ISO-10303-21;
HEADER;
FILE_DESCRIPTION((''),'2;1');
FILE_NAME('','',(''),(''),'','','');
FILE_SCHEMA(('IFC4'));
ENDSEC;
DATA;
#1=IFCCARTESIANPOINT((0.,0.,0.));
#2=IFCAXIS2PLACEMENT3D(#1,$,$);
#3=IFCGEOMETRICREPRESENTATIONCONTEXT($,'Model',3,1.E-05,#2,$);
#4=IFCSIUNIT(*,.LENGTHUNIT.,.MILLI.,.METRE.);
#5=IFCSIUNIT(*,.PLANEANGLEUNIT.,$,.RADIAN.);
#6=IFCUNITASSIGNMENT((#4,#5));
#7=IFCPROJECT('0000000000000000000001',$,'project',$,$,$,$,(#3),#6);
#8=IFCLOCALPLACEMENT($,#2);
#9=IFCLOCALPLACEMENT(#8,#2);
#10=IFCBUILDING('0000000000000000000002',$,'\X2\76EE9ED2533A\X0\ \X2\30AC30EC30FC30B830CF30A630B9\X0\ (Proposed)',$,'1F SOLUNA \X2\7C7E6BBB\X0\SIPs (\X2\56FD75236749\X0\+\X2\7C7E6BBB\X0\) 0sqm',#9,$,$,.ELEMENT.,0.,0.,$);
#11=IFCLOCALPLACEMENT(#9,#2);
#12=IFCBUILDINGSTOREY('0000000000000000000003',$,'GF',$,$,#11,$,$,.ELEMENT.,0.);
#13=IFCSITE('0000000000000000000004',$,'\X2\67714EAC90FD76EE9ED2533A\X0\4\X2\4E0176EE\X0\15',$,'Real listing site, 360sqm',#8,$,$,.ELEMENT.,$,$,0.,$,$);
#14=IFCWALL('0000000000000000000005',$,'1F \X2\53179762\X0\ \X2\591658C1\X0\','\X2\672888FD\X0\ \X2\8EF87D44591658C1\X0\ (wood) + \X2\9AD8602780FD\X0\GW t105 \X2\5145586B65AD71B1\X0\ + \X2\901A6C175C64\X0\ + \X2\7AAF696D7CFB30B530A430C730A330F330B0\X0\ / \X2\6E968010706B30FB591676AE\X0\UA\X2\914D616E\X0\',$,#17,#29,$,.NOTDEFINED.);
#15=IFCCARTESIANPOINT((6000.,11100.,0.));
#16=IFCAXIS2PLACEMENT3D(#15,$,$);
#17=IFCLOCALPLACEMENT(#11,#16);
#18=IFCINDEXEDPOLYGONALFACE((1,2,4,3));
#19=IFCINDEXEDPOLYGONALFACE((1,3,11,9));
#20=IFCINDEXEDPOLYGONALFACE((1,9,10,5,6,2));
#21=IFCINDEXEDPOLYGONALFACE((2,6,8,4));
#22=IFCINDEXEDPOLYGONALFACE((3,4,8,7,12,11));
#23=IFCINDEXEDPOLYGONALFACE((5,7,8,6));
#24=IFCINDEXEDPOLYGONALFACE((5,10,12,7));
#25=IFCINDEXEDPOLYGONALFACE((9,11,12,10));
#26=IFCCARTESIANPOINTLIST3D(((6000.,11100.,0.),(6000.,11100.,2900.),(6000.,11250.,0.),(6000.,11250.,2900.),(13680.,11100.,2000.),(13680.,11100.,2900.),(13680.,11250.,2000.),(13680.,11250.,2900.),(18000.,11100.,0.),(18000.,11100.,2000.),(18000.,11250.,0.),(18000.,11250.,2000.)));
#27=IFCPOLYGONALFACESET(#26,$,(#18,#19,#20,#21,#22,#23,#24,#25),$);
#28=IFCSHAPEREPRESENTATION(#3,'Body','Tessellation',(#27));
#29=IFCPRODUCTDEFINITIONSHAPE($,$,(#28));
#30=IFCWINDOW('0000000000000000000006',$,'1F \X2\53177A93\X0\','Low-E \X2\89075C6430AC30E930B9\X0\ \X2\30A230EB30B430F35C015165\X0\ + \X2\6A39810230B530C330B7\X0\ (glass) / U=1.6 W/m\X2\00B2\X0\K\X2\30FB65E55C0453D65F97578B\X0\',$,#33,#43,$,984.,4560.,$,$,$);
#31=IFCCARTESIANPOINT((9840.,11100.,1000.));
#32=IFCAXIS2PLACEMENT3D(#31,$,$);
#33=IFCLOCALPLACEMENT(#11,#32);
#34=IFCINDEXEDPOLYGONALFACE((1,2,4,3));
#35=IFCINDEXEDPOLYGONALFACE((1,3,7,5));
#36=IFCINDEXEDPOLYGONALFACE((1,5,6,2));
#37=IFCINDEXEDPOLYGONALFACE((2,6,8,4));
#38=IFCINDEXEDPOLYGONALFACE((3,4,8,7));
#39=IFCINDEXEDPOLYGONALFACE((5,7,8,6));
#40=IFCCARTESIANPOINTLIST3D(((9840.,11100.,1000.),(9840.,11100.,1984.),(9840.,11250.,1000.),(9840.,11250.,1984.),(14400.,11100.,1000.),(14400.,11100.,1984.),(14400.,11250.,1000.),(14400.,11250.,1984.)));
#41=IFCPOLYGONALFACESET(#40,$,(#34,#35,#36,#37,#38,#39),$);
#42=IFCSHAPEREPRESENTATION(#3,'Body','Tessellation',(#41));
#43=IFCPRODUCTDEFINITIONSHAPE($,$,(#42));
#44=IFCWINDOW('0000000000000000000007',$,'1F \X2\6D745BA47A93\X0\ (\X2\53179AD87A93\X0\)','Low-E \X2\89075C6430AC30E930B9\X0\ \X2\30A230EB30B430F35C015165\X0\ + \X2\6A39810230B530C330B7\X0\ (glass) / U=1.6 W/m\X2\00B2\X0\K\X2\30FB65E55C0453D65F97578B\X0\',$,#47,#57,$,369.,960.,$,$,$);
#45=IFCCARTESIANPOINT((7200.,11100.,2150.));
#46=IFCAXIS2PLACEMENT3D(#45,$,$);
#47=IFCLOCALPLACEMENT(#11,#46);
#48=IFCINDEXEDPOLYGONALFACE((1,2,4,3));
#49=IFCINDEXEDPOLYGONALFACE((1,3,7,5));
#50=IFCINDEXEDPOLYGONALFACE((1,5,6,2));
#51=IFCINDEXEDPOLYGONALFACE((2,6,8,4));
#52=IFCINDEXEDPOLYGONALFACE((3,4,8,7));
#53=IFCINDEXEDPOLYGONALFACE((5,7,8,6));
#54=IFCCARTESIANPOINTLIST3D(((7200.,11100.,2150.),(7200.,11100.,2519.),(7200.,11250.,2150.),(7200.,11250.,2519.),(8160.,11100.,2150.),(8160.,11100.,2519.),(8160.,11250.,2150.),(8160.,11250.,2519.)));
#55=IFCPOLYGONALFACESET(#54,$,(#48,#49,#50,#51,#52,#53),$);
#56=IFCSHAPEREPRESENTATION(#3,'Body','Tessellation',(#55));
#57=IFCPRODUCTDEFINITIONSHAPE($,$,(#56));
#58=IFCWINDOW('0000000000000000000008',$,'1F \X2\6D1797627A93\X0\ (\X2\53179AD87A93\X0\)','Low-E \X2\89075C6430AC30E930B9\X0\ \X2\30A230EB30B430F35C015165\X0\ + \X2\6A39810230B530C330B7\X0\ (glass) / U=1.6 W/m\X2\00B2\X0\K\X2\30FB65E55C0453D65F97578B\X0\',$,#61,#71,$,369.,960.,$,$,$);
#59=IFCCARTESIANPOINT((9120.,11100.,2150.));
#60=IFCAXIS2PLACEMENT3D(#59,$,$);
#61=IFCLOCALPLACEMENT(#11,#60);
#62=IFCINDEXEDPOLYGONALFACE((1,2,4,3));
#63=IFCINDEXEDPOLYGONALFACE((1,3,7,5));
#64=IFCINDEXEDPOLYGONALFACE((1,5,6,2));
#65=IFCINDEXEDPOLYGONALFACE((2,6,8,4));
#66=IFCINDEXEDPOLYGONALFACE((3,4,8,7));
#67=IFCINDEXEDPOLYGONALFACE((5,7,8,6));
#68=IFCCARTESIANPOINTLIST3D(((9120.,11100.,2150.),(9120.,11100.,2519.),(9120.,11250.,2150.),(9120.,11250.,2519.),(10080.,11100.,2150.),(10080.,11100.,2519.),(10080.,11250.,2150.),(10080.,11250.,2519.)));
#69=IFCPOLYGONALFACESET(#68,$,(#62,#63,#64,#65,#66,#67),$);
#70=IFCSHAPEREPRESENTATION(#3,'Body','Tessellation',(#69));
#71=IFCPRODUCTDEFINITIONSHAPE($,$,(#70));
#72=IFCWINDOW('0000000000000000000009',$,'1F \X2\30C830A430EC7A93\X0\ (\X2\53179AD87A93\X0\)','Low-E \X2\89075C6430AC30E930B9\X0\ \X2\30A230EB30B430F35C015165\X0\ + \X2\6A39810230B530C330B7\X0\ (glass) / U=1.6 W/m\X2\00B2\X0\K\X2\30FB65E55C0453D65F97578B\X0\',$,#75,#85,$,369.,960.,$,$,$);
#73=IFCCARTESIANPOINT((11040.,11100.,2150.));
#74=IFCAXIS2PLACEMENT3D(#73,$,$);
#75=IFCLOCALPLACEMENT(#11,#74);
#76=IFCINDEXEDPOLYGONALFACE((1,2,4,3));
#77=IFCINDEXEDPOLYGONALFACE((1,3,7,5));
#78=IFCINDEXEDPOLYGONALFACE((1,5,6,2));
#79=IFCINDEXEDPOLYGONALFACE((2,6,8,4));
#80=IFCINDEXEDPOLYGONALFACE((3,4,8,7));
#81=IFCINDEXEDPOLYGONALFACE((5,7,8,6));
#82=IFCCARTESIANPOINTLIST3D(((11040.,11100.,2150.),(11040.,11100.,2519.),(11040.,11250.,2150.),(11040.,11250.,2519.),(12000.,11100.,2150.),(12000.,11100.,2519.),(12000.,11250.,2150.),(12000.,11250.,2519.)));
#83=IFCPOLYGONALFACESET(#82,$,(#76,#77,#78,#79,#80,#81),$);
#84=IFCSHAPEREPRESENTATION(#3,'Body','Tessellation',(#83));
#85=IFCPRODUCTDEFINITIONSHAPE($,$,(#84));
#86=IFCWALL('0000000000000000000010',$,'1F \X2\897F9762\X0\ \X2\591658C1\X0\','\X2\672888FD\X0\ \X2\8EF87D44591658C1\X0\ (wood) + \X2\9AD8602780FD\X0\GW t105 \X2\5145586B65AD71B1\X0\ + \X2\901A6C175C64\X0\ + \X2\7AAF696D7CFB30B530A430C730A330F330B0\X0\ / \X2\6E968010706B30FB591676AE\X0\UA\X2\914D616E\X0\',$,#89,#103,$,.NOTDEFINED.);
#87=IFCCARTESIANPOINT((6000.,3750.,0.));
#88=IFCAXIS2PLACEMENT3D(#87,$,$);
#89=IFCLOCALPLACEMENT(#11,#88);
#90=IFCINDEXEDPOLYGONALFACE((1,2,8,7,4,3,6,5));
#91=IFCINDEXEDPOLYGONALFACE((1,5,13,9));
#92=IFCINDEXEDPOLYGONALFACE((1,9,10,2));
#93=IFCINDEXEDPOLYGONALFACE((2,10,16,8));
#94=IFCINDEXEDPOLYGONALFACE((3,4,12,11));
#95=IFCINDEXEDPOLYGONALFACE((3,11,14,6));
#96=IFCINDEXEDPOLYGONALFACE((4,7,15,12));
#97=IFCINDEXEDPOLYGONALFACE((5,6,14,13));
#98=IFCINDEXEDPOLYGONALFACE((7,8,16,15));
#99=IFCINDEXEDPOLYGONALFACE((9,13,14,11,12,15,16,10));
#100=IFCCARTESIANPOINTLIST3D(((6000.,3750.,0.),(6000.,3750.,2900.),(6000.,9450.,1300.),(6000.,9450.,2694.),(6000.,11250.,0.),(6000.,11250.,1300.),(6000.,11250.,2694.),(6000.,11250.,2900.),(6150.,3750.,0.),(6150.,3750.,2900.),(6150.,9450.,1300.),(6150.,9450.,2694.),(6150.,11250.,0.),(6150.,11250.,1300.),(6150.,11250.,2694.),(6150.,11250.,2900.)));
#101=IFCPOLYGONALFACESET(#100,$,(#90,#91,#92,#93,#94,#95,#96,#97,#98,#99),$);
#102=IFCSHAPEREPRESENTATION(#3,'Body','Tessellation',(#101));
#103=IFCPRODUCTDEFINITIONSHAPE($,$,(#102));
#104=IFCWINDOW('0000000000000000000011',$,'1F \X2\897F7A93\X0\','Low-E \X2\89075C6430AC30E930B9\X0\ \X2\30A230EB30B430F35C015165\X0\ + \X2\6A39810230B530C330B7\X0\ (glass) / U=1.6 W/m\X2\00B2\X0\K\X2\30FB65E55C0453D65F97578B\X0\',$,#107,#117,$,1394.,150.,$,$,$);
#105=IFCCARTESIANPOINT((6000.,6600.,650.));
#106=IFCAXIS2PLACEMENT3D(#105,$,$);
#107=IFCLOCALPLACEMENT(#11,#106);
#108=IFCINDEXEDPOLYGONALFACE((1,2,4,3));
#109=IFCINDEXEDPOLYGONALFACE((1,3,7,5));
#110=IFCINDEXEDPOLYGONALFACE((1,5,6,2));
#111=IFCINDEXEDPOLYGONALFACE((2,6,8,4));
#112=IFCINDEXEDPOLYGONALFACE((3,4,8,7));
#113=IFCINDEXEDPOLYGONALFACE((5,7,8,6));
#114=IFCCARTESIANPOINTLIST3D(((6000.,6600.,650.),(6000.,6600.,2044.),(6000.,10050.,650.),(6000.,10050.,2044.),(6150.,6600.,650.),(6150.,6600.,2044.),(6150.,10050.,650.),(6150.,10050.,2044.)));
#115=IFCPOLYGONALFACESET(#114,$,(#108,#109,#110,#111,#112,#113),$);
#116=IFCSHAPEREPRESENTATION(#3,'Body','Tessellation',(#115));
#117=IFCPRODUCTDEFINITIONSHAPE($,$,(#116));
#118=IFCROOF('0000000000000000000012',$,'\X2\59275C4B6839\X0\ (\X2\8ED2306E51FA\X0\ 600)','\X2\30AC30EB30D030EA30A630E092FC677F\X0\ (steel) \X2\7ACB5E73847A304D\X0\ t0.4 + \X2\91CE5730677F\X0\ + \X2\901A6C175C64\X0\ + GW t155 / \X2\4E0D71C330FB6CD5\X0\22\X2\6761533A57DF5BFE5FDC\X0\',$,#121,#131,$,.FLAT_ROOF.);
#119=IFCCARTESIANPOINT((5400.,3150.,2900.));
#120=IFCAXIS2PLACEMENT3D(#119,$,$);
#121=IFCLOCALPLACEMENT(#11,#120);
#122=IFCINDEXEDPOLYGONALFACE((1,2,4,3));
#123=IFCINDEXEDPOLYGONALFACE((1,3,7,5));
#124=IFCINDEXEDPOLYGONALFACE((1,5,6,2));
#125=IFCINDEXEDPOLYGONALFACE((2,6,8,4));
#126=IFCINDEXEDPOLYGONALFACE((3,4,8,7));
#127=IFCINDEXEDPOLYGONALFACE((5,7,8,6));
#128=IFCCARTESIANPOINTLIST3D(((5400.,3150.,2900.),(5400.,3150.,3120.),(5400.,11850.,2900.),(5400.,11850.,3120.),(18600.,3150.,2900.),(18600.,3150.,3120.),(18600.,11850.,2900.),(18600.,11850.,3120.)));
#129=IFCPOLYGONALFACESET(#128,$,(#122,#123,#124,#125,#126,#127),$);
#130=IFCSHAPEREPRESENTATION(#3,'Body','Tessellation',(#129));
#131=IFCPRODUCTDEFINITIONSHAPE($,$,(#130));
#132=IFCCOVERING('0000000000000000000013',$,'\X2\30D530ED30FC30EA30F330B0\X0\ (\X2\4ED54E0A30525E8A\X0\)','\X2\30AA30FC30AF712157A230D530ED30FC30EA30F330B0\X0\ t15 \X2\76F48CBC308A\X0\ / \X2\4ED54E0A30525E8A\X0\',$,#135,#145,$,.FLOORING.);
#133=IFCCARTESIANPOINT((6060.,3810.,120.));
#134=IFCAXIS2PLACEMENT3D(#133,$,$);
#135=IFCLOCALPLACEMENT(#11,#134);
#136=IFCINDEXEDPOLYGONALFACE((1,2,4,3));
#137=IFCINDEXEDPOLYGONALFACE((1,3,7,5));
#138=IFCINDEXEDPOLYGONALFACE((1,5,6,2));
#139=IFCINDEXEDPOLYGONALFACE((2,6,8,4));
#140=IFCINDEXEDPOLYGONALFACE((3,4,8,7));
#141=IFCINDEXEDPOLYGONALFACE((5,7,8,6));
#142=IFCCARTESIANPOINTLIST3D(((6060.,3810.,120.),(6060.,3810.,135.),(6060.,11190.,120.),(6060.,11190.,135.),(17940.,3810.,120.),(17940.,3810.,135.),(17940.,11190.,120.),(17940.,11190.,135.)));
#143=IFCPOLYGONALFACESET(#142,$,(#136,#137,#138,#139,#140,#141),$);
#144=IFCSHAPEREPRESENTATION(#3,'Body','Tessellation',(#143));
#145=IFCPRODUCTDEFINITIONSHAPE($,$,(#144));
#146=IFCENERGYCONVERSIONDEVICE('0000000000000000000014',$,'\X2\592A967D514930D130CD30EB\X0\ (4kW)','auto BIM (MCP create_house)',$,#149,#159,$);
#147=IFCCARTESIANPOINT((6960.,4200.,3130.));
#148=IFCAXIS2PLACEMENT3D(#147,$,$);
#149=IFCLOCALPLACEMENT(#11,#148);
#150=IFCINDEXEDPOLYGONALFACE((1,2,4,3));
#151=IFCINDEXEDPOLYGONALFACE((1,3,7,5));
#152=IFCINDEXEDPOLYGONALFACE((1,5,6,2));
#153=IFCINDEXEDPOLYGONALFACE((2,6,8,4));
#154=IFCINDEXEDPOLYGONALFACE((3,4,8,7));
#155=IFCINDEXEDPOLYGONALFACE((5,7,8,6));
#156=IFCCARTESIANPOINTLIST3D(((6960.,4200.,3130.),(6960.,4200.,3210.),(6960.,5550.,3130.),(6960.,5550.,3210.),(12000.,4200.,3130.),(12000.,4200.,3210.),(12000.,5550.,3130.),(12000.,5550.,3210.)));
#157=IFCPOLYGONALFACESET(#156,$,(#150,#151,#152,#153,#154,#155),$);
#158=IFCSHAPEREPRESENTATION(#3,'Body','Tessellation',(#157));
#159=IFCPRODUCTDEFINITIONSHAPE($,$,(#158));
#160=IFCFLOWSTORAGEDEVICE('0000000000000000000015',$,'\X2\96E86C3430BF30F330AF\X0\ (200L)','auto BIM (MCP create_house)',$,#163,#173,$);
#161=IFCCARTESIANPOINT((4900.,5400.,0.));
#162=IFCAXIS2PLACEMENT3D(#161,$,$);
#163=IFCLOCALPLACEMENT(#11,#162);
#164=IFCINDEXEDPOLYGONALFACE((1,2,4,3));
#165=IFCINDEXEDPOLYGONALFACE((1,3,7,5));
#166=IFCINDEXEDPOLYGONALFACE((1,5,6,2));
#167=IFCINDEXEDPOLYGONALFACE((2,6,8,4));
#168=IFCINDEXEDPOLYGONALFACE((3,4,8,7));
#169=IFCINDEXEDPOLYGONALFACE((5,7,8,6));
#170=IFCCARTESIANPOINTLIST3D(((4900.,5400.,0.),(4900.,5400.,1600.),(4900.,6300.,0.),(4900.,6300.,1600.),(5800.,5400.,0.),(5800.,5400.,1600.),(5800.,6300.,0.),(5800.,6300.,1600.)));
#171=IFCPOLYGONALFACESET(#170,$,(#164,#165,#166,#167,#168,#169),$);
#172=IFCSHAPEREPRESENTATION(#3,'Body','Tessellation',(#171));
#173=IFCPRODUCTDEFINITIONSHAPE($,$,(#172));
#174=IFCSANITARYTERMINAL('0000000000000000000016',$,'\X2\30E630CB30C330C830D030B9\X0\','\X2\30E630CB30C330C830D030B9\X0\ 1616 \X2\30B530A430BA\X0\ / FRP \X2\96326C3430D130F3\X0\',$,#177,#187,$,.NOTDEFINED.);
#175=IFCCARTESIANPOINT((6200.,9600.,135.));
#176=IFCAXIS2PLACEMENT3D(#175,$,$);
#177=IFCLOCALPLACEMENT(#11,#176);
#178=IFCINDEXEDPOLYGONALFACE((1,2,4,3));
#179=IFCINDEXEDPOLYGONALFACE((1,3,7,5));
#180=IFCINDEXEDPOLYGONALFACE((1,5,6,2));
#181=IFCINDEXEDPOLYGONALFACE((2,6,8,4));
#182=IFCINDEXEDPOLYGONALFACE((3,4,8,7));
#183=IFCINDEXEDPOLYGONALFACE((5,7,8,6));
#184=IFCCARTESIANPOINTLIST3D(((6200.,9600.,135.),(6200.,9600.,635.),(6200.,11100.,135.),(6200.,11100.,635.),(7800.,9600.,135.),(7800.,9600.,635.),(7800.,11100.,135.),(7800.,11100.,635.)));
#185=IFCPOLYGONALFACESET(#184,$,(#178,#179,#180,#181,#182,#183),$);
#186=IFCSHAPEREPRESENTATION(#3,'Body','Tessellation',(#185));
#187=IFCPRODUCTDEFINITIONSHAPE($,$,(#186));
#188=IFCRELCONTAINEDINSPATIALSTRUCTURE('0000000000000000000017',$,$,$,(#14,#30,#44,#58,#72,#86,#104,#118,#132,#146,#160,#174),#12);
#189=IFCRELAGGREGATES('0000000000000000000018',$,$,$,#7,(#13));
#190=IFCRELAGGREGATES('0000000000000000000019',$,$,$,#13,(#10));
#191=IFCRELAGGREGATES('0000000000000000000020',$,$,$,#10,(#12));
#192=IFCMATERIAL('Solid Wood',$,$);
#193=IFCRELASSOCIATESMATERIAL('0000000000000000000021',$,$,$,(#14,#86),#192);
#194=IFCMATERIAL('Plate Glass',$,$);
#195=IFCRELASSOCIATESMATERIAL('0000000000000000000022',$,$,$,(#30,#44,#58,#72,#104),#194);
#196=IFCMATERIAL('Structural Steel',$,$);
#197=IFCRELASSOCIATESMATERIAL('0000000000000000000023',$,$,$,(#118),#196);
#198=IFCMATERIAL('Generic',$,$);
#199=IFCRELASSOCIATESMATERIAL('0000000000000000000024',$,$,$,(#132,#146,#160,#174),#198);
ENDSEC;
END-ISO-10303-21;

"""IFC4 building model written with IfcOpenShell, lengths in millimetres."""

from ifc_helpers import new_model, si_unit, frame, frame_2d, origin, place, context, project, spatial, rectangle, extrude, material, element, fill, save


model = new_model("IFC4")

# Units and contexts
model_context = context("Model", 3, precision=1e-05, world=origin())
ifc_project = project(units=[si_unit("LENGTHUNIT", "METRE", prefix="MILLI"), si_unit("PLANEANGLEUNIT", "RADIAN")], contexts=[model_context])

# Site, building, storey
site_placement = place(None, origin())
site = spatial("IfcSite", under=ifc_project, at=site_placement, Name="東京都目黒区4丁目15", ObjectType="Real listing site, 360sqm", CompositionType="ELEMENT", RefElevation=0.0)
building_placement = place(site_placement, origin())
building = spatial("IfcBuilding", under=site, at=building_placement, Name="目黒区 ガレージハウス (Proposed)", ObjectType="1F SOLUNA 籾殻SIPs (国産杉+籾殻) 0sqm", CompositionType="ELEMENT", ElevationOfRefHeight=0.0, ElevationOfTerrain=0.0)
storey_placement = place(building_placement, origin())
storey = spatial("IfcBuildingStorey", under=building, at=storey_placement, Name="GF", CompositionType="ELEMENT", Elevation=0.0)

# Shared definitions
ifc_material_1 = material(Name="Solid Wood")

# Shared definitions
ifc_material_2 = material(Name="Plate Glass")

# Wall, openings, windows
wall_1_placement = place(storey_placement, frame((6000.0, 11100.0, 0.0)))
wall_1 = element("IfcWall", 1, at=wall_1_placement, inside=storey, material=ifc_material_1, Name="1F 北面 外壁", Description="木製 軸組外壁 (wood) + 高性能GW t105 充填断熱 + 通気層 + 窯業系サイディング / 準耐火・外皮UA配慮", PredefinedType="NOTDEFINED", context=model_context, shape_type="SweptSolid", body=[
    extrude(rectangle(XDim=12000.0, YDim=150.0, at=frame_2d((6000.0, 75.0))), frame((6000.0, 11100.0, 0.0)), (0.0, 0.0, 1.0), 2900.0),
])
opening_1_placement = place(storey_placement, frame((9840.0, 11100.0, 1000.0)))
opening_1 = element("IfcOpeningElement", 2, at=opening_1_placement, cuts=wall_1, PredefinedType="NOTDEFINED", context=model_context, shape_type="SweptSolid", body=[
    extrude(rectangle(XDim=4560.0, YDim=150.0, at=frame_2d((2280.0, 75.0))), frame((9840.0, 11100.0, 1000.0)), (0.0, 0.0, 1.0), 984.0),
])
opening_2_placement = place(storey_placement, frame((7200.0, 11100.0, 2150.0)))
opening_2 = element("IfcOpeningElement", 3, at=opening_2_placement, cuts=wall_1, PredefinedType="NOTDEFINED", context=model_context, shape_type="SweptSolid", body=[
    extrude(rectangle(XDim=960.0, YDim=150.0, at=frame_2d((480.0, 75.0))), frame((7200.0, 11100.0, 2150.0)), (0.0, 0.0, 1.0), 369.0),
])
opening_3_placement = place(storey_placement, frame((9120.0, 11100.0, 2150.0)))
opening_3 = element("IfcOpeningElement", 4, at=opening_3_placement, cuts=wall_1, PredefinedType="NOTDEFINED", context=model_context, shape_type="SweptSolid", body=[
    extrude(rectangle(XDim=960.0, YDim=150.0, at=frame_2d((480.0, 75.0))), frame((9120.0, 11100.0, 2150.0)), (0.0, 0.0, 1.0), 369.0),
])
opening_4_placement = place(storey_placement, frame((11040.0, 11100.0, 2150.0)))
opening_4 = element("IfcOpeningElement", 5, at=opening_4_placement, cuts=wall_1, PredefinedType="NOTDEFINED", context=model_context, shape_type="SweptSolid", body=[
    extrude(rectangle(XDim=960.0, YDim=150.0, at=frame_2d((480.0, 75.0))), frame((11040.0, 11100.0, 2150.0)), (0.0, 0.0, 1.0), 369.0),
])
window_1_placement = place(storey_placement, frame((9840.0, 11100.0, 1000.0)))
window_1 = element("IfcWindow", 6, at=window_1_placement, inside=storey, material=ifc_material_2, Name="1F 北窓", Description="Low-E 複層ガラス アルゴン封入 + 樹脂サッシ (glass) / U=1.6 W/m²K・日射取得型", OverallHeight=984.0, OverallWidth=4560.0, context=model_context, shape_type="SweptSolid", body=[
    extrude(rectangle(XDim=4560.0, YDim=150.0, at=frame_2d((2280.0, 75.0))), frame((9840.0, 11100.0, 1000.0)), (0.0, 0.0, 1.0), 984.0),
])
fill(opening_1, window_1)
window_2_placement = place(storey_placement, frame((7200.0, 11100.0, 2150.0)))
window_2 = element("IfcWindow", 7, at=window_2_placement, inside=storey, material=ifc_material_2, Name="1F 浴室窓 (北高窓)", Description="Low-E 複層ガラス アルゴン封入 + 樹脂サッシ (glass) / U=1.6 W/m²K・日射取得型", OverallHeight=369.0, OverallWidth=960.0, context=model_context, shape_type="SweptSolid", body=[
    extrude(rectangle(XDim=960.0, YDim=150.0, at=frame_2d((480.0, 75.0))), frame((7200.0, 11100.0, 2150.0)), (0.0, 0.0, 1.0), 369.0),
])
fill(opening_2, window_2)
window_3_placement = place(storey_placement, frame((9120.0, 11100.0, 2150.0)))
window_3 = element("IfcWindow", 8, at=window_3_placement, inside=storey, material=ifc_material_2, Name="1F 洗面窓 (北高窓)", Description="Low-E 複層ガラス アルゴン封入 + 樹脂サッシ (glass) / U=1.6 W/m²K・日射取得型", OverallHeight=369.0, OverallWidth=960.0, context=model_context, shape_type="SweptSolid", body=[
    extrude(rectangle(XDim=960.0, YDim=150.0, at=frame_2d((480.0, 75.0))), frame((9120.0, 11100.0, 2150.0)), (0.0, 0.0, 1.0), 369.0),
])
fill(opening_3, window_3)
window_4_placement = place(storey_placement, frame((11040.0, 11100.0, 2150.0)))
window_4 = element("IfcWindow", 9, at=window_4_placement, inside=storey, material=ifc_material_2, Name="1F トイレ窓 (北高窓)", Description="Low-E 複層ガラス アルゴン封入 + 樹脂サッシ (glass) / U=1.6 W/m²K・日射取得型", OverallHeight=369.0, OverallWidth=960.0, context=model_context, shape_type="SweptSolid", body=[
    extrude(rectangle(XDim=960.0, YDim=150.0, at=frame_2d((480.0, 75.0))), frame((11040.0, 11100.0, 2150.0)), (0.0, 0.0, 1.0), 369.0),
])
fill(opening_4, window_4)

# Wall, opening, window
wall_2_placement = place(storey_placement, frame((6000.0, 3750.0, 0.0)))
wall_2 = element("IfcWall", 10, at=wall_2_placement, inside=storey, material=ifc_material_1, Name="1F 西面 外壁", Description="木製 軸組外壁 (wood) + 高性能GW t105 充填断熱 + 通気層 + 窯業系サイディング / 準耐火・外皮UA配慮", PredefinedType="NOTDEFINED", context=model_context, shape_type="SweptSolid", body=[
    extrude(rectangle(XDim=150.0, YDim=7500.0, at=frame_2d((75.0, 3750.0))), frame((6000.0, 3750.0, 0.0)), (0.0, 0.0, 1.0), 2900.0),
])
opening_5_placement = place(storey_placement, frame((6000.0, 6600.0, 650.0)))
opening_5 = element("IfcOpeningElement", 11, at=opening_5_placement, cuts=wall_2, PredefinedType="NOTDEFINED", context=model_context, shape_type="SweptSolid", body=[
    extrude(rectangle(XDim=150.0, YDim=3450.0, at=frame_2d((75.0, 1725.0))), frame((6000.0, 6600.0, 650.0)), (0.0, 0.0, 1.0), 1394.0),
])
window_5_placement = place(storey_placement, frame((6000.0, 6600.0, 650.0)))
window_5 = element("IfcWindow", 12, at=window_5_placement, inside=storey, material=ifc_material_2, Name="1F 西窓", Description="Low-E 複層ガラス アルゴン封入 + 樹脂サッシ (glass) / U=1.6 W/m²K・日射取得型", OverallHeight=1394.0, OverallWidth=150.0, context=model_context, shape_type="SweptSolid", body=[
    extrude(rectangle(XDim=150.0, YDim=3450.0, at=frame_2d((75.0, 1725.0))), frame((6000.0, 6600.0, 650.0)), (0.0, 0.0, 1.0), 1394.0),
])
fill(opening_5, window_5)

# Roof
ifc_material_3 = material(Name="Structural Steel")
roof_placement = place(storey_placement, frame((5400.0, 3150.0, 2900.0)))
element("IfcRoof", 13, at=roof_placement, inside=storey, material=ifc_material_3, Name="大屋根 (軒の出 600)", Description="ガルバリウム鋼板 (steel) 立平葺き t0.4 + 野地板 + 通気層 + GW t155 / 不燃・法22条区域対応", PredefinedType="FLAT_ROOF", context=model_context, shape_type="SweptSolid", body=[
    extrude(rectangle(XDim=13200.0, YDim=8700.0, at=frame_2d((6600.0, 4350.0))), frame((5400.0, 3150.0, 2900.0)), (0.0, 0.0, 1.0), 220.0),
])

# Covering
ifc_material_4 = material(Name="Generic")
covering_placement = place(storey_placement, frame((6060.0, 3810.0, 120.0)))
element("IfcCovering", 14, at=covering_placement, inside=storey, material=ifc_material_4, Name="フローリング (仕上げ床)", Description="オーク無垢フローリング t15 直貼り / 仕上げ床", PredefinedType="FLOORING", context=model_context, shape_type="SweptSolid", body=[
    extrude(rectangle(XDim=11880.0, YDim=7380.0, at=frame_2d((5940.0, 3690.0))), frame((6060.0, 3810.0, 120.0)), (0.0, 0.0, 1.0), 15.0),
])

# Energy conversion device
energy_conversion_device_placement = place(storey_placement, frame((6960.0, 4200.0, 3130.0)))
element("IfcEnergyConversionDevice", 15, at=energy_conversion_device_placement, inside=storey, material=ifc_material_4, Name="太陽光パネル (4kW)", Description="auto BIM (MCP create_house)", context=model_context, shape_type="SweptSolid", body=[
    extrude(rectangle(XDim=5040.0, YDim=1350.0, at=frame_2d((2520.0, 675.0))), frame((6960.0, 4200.0, 3130.0)), (0.0, 0.0, 1.0), 80.0),
])

# Flow storage device
flow_storage_device_placement = place(storey_placement, frame((4900.0, 5400.0, 0.0)))
element("IfcFlowStorageDevice", 16, at=flow_storage_device_placement, inside=storey, material=ifc_material_4, Name="雨水タンク (200L)", Description="auto BIM (MCP create_house)", context=model_context, shape_type="SweptSolid", body=[
    extrude(rectangle(XDim=900.0, YDim=900.0, at=frame_2d((450.0, 450.0))), frame((4900.0, 5400.0, 0.0)), (0.0, 0.0, 1.0), 1600.0),
])

# Sanitary terminal
sanitary_terminal_placement = place(storey_placement, frame((6200.0, 9600.0, 135.0)))
element("IfcSanitaryTerminal", 17, at=sanitary_terminal_placement, inside=storey, material=ifc_material_4, Name="ユニットバス", Description="ユニットバス 1616 サイズ / FRP 防水パン", PredefinedType="NOTDEFINED", context=model_context, shape_type="SweptSolid", body=[
    extrude(rectangle(XDim=1600.0, YDim=1500.0, at=frame_2d((800.0, 750.0))), frame((6200.0, 9600.0, 135.0)), (0.0, 0.0, 1.0), 500.0),
])

save(model, "model.ifc")
